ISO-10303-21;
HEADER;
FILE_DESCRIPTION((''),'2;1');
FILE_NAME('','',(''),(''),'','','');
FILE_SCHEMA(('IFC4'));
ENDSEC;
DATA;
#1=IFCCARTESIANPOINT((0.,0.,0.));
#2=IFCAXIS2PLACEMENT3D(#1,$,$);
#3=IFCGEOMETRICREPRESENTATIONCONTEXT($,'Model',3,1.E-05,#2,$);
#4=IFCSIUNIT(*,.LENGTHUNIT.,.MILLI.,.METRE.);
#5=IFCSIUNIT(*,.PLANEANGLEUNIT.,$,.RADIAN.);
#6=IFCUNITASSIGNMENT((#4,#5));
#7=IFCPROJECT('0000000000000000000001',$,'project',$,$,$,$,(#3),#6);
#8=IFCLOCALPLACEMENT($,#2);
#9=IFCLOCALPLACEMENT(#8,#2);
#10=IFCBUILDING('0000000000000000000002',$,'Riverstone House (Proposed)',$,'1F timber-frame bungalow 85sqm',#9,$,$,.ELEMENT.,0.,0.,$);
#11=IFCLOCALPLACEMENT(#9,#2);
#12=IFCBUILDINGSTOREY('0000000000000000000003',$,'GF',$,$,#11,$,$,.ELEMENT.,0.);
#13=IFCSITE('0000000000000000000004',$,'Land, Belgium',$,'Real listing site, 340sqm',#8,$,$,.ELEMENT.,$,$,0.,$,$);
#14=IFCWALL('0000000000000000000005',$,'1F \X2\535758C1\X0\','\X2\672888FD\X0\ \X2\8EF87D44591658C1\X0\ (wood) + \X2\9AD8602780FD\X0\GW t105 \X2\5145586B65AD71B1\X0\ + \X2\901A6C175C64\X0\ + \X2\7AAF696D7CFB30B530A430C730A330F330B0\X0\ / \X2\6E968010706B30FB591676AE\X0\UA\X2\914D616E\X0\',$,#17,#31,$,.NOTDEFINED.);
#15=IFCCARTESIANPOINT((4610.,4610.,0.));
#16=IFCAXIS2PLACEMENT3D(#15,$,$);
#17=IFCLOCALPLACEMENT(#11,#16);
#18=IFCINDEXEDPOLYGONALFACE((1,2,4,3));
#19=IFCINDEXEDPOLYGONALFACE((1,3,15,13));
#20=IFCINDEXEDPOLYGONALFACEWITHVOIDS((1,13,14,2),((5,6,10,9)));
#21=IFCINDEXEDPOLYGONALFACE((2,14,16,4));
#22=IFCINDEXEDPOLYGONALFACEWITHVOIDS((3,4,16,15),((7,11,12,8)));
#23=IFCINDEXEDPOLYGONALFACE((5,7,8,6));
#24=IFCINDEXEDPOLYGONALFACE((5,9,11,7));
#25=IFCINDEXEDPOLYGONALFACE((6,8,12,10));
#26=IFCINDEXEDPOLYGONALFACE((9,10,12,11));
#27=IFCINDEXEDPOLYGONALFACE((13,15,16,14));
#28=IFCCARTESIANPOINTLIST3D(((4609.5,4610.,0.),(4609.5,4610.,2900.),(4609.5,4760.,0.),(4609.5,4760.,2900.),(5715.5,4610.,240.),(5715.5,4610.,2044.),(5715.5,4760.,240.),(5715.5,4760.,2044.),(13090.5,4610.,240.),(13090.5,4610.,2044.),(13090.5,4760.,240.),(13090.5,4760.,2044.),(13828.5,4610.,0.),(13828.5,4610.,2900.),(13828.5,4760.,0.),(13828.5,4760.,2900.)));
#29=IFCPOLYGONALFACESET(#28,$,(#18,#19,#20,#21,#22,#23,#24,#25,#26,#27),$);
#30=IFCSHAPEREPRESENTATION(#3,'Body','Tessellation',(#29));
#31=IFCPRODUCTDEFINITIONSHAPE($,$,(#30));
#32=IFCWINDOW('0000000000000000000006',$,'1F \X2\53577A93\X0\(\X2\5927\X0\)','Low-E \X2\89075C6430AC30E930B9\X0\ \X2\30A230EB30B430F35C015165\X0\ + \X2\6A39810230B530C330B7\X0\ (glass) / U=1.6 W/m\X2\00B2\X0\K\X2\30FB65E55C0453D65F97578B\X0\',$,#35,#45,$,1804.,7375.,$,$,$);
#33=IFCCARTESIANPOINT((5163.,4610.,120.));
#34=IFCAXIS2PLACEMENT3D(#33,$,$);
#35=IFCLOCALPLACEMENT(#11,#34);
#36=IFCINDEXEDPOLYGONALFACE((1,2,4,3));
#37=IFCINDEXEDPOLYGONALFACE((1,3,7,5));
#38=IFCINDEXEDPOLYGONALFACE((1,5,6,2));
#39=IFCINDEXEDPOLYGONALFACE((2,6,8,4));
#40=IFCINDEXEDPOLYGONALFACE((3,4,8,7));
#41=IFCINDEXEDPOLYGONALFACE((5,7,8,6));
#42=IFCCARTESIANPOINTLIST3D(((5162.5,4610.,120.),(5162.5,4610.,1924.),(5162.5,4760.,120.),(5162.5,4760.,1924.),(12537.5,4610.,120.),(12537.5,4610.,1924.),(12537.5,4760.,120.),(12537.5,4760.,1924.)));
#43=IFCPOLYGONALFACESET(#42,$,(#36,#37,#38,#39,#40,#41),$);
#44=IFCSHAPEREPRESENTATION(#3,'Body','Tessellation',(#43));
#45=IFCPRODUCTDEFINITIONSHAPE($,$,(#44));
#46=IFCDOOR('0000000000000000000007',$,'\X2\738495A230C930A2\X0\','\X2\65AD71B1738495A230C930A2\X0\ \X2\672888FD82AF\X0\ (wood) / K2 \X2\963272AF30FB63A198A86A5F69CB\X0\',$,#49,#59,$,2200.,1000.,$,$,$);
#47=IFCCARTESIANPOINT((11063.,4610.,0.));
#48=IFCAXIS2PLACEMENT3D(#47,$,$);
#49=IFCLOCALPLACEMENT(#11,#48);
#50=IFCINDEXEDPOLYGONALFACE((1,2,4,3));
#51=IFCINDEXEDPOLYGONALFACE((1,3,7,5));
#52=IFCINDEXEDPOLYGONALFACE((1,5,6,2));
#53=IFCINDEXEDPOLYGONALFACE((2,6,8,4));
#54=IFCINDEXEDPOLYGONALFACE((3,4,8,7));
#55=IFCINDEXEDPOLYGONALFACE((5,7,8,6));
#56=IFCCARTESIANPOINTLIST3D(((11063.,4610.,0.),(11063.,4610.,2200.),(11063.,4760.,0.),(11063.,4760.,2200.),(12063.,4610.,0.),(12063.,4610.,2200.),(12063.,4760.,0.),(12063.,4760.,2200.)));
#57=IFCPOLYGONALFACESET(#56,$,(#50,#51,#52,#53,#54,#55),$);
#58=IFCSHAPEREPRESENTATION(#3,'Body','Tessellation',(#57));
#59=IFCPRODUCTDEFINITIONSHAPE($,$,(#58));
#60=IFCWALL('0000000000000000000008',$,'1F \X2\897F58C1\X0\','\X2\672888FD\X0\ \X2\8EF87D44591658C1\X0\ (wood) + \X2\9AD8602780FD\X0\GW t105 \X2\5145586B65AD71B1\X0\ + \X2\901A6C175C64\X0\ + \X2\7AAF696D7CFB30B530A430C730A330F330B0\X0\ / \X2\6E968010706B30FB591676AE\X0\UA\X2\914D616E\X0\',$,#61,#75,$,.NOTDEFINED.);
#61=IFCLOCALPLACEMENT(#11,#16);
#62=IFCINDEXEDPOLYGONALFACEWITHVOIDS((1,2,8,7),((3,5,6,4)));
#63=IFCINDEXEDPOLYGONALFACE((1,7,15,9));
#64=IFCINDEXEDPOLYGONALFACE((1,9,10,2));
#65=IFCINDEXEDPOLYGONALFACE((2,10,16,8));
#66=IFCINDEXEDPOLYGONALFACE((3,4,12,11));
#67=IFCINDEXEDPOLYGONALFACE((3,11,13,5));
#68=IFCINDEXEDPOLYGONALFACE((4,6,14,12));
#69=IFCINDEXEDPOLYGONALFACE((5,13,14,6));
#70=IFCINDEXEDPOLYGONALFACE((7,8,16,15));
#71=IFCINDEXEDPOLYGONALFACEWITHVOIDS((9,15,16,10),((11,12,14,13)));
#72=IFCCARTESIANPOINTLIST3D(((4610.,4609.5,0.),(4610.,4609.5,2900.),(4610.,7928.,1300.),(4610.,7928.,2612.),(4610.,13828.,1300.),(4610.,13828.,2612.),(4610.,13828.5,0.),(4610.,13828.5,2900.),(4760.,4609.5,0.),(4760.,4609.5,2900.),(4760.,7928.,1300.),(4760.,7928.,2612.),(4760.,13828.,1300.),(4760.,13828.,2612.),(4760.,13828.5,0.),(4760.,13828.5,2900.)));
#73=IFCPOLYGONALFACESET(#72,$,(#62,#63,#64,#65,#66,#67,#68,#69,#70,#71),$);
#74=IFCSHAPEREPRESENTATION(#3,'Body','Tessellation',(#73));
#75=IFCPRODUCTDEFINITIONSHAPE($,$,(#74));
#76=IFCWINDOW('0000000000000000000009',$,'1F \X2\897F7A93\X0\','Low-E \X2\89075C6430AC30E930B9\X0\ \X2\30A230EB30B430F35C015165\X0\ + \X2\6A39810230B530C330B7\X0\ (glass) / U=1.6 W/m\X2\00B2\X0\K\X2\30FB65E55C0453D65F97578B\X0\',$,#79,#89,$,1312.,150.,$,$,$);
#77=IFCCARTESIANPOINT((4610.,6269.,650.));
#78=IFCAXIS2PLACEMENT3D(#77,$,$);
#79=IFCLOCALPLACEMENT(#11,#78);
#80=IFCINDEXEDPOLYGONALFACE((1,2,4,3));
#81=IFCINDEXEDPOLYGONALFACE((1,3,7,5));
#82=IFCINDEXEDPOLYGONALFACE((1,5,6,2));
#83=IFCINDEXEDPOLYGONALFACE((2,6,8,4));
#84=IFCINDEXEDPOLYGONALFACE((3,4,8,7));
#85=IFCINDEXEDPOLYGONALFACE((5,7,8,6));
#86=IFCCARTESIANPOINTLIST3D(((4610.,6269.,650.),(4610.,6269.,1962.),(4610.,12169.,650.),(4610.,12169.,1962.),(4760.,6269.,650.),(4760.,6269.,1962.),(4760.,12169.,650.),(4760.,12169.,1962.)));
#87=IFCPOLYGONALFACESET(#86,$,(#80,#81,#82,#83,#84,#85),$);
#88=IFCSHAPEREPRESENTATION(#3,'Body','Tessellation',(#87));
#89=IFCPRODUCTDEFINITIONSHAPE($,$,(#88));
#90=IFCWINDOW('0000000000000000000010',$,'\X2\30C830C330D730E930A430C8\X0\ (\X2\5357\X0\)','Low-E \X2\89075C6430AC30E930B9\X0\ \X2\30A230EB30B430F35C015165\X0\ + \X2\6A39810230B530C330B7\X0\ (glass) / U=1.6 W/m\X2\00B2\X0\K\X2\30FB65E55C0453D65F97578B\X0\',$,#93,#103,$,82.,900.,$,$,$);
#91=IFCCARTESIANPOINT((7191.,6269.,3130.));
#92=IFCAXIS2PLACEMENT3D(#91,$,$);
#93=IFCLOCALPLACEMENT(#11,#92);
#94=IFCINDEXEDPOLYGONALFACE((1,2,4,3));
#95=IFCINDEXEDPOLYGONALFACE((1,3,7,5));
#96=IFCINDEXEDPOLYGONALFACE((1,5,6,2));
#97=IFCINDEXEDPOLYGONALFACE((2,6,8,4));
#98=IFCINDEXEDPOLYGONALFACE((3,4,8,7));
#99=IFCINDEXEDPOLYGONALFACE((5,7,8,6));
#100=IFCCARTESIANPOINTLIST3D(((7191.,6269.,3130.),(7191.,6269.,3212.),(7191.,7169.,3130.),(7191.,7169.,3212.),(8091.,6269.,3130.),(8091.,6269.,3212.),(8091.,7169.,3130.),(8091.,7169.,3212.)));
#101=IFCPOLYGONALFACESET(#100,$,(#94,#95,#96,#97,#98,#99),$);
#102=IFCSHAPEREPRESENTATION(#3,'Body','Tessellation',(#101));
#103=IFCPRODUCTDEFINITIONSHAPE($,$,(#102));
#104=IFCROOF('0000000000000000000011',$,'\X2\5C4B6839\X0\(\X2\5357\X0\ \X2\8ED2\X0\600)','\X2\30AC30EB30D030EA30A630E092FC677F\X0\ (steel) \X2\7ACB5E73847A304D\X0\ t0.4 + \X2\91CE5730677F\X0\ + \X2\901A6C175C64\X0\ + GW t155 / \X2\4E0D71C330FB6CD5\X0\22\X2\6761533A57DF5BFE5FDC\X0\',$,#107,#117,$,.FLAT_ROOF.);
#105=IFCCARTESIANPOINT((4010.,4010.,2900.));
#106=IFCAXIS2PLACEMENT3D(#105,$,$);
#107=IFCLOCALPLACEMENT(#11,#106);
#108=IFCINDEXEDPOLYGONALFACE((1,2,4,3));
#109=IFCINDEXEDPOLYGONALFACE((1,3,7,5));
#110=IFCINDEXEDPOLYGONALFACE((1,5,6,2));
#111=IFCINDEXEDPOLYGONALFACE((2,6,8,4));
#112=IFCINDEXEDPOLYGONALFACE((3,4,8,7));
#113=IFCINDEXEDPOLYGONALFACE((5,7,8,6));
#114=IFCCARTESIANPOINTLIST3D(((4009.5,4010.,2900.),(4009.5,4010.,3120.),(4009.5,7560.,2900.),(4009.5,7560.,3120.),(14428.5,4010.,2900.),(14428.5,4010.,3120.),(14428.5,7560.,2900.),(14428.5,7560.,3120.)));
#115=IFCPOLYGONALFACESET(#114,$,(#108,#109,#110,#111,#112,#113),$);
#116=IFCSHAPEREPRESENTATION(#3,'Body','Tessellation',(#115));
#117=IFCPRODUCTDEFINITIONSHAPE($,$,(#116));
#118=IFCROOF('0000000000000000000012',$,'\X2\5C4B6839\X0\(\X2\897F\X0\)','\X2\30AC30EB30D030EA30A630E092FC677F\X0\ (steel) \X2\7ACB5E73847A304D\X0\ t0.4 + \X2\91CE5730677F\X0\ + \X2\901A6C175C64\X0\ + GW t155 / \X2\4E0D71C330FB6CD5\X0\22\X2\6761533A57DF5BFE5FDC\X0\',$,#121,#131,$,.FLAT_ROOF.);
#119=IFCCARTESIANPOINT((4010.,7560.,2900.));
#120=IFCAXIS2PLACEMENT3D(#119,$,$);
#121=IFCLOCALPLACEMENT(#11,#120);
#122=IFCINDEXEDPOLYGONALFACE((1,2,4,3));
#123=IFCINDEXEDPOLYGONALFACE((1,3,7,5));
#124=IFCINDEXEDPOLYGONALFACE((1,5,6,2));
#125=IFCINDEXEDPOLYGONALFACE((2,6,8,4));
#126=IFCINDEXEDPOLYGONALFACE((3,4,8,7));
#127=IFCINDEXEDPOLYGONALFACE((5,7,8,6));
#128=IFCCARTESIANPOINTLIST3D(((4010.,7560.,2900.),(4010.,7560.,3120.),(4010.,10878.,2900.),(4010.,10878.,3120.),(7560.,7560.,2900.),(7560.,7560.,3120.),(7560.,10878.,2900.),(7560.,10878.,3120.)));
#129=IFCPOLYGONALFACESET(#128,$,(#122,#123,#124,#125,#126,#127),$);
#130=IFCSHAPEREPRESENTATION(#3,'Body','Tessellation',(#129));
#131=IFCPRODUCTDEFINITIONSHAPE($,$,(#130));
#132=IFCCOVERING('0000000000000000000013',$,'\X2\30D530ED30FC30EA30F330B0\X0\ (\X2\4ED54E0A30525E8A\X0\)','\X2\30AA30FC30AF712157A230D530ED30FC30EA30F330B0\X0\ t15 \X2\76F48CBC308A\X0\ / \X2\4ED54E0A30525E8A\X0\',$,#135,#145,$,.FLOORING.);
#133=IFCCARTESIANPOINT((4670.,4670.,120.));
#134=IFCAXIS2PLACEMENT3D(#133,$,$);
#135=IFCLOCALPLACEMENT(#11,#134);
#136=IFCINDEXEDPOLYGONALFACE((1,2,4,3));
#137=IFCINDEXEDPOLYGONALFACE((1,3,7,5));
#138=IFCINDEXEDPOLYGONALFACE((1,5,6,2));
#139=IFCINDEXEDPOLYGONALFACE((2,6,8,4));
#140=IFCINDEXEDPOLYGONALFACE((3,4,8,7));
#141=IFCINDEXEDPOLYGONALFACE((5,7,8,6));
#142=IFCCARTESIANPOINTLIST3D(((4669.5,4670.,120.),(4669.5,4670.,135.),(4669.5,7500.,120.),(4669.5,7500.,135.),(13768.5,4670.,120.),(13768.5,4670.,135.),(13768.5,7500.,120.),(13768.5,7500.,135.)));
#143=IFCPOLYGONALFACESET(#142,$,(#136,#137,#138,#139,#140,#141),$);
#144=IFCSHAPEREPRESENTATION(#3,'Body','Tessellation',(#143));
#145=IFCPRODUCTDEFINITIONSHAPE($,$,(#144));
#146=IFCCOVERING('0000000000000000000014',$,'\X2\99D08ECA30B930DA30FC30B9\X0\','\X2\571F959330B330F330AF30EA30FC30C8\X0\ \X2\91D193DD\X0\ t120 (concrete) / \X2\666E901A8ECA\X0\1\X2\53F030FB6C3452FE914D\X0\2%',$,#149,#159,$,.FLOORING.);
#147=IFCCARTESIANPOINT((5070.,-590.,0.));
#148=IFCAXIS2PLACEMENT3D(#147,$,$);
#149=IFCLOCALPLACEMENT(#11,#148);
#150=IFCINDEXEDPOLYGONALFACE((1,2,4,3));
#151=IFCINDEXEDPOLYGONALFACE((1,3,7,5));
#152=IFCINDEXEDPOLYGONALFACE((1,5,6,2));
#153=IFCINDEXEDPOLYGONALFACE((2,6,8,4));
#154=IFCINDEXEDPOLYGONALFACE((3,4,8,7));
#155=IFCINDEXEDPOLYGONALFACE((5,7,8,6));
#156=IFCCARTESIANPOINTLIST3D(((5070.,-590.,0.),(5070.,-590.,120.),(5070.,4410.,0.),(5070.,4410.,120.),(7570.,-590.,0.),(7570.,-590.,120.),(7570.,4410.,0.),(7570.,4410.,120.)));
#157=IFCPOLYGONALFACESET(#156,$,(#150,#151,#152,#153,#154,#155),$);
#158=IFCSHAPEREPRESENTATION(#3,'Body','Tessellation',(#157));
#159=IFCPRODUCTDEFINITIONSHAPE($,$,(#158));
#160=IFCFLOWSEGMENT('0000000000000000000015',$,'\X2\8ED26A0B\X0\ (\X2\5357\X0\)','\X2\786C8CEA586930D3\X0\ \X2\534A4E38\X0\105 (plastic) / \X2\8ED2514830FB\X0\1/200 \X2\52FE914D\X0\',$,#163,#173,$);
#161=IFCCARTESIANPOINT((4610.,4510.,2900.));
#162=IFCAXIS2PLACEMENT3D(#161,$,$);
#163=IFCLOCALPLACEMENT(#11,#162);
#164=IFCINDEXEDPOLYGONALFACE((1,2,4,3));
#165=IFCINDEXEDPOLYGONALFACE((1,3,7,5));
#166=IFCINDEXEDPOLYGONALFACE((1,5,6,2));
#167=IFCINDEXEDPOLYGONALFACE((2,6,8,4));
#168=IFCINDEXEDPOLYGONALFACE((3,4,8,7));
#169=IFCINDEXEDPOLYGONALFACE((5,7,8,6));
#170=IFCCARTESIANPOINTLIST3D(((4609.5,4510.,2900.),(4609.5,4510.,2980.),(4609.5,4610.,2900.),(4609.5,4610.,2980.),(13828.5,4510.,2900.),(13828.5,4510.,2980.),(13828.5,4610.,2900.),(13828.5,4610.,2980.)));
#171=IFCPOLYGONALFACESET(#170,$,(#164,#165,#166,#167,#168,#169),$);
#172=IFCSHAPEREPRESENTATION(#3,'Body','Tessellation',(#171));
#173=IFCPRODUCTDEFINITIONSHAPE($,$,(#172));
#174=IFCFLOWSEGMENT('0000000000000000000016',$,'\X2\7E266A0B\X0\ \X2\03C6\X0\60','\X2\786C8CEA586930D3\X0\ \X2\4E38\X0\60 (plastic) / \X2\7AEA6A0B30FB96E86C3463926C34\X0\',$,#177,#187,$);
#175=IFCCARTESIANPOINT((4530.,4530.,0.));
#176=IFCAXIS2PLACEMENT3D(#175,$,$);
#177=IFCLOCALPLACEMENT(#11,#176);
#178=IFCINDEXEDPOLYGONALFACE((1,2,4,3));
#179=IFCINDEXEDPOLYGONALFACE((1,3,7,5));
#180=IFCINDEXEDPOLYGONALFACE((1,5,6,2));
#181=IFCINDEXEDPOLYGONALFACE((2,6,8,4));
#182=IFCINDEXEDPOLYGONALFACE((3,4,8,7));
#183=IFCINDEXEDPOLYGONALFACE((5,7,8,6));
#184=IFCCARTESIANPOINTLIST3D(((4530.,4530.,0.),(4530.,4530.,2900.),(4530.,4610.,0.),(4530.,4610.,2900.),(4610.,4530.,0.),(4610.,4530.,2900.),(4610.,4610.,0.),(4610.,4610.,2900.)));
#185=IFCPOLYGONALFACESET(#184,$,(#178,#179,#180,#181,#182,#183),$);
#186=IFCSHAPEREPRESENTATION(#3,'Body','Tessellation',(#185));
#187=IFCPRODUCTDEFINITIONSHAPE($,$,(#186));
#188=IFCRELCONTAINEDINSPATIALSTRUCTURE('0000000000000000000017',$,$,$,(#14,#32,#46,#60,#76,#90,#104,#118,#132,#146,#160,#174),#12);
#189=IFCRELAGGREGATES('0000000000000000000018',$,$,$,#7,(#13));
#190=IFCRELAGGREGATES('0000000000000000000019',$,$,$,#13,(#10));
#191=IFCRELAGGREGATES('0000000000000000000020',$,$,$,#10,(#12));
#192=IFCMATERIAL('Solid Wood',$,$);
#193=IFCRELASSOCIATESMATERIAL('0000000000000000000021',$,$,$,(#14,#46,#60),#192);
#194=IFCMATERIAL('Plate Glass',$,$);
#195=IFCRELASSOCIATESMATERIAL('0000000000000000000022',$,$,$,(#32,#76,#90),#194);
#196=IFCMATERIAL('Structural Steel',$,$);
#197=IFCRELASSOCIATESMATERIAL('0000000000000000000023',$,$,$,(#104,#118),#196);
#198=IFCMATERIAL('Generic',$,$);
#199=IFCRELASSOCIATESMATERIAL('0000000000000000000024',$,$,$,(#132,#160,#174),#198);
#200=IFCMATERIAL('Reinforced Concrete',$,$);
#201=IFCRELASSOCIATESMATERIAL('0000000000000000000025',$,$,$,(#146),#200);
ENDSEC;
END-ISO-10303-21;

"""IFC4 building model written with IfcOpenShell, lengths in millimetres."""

from ifc_helpers import new_model, si_unit, frame, frame_2d, origin, place, context, project, spatial, rectangle, extrude, material, element, fill, save


model = new_model("IFC4")

# Units and contexts
model_context = context("Model", 3, precision=1e-05, world=origin())
ifc_project = project(units=[si_unit("LENGTHUNIT", "METRE", prefix="MILLI"), si_unit("PLANEANGLEUNIT", "RADIAN")], contexts=[model_context])

# Site, building, storey
site_placement = place(None, origin())
site = spatial("IfcSite", under=ifc_project, at=site_placement, Name="Land, Belgium", ObjectType="Real listing site, 340sqm", CompositionType="ELEMENT", RefElevation=0.0)
building_placement = place(site_placement, origin())
building = spatial("IfcBuilding", under=site, at=building_placement, Name="Riverstone House (Proposed)", ObjectType="1F timber-frame bungalow 85sqm", CompositionType="ELEMENT", ElevationOfRefHeight=0.0, ElevationOfTerrain=0.0)
storey_placement = place(building_placement, origin())
storey = spatial("IfcBuildingStorey", under=building, at=storey_placement, Name="GF", CompositionType="ELEMENT", Elevation=0.0)

# Shared definitions
ifc_material_1 = material(Name="Solid Wood")

# Shared definitions
ifc_material_2 = material(Name="Reinforced Concrete")

# Wall, openings, window, door
wall_1_placement = place(storey_placement, frame((4610.0, 4610.0, 0.0)))
wall_1 = element("IfcWall", 1, at=wall_1_placement, inside=storey, material=ifc_material_1, Name="1F 南壁", Description="木製 軸組外壁 (wood) + 高性能GW t105 充填断熱 + 通気層 + 窯業系サイディング / 準耐火・外皮UA配慮", PredefinedType="NOTDEFINED", context=model_context, shape_type="SweptSolid", body=[
    extrude(rectangle(XDim=9219.0, YDim=150.0, at=frame_2d((4609.0, 75.0))), frame((4610.0, 4610.0, 0.0)), (0.0, 0.0, 1.0), 2900.0),
])
opening_1_placement = place(storey_placement, frame((5163.0, 4610.0, 120.0)))
opening_1 = element("IfcOpeningElement", 2, at=opening_1_placement, cuts=wall_1, PredefinedType="NOTDEFINED", context=model_context, shape_type="SweptSolid", body=[
    extrude(rectangle(XDim=7375.0, YDim=150.0, at=frame_2d((3687.0, 75.0))), frame((5163.0, 4610.0, 120.0)), (0.0, 0.0, 1.0), 1804.0),
])
opening_2_placement = place(storey_placement, frame((11063.0, 4610.0, 0.0)))
opening_2 = element("IfcOpeningElement", 3, at=opening_2_placement, cuts=wall_1, PredefinedType="NOTDEFINED", context=model_context, shape_type="SweptSolid", body=[
    extrude(rectangle(XDim=1000.0, YDim=150.0, at=frame_2d((500.0, 75.0))), frame((11063.0, 4610.0, 0.0)), (0.0, 0.0, 1.0), 2200.0),
])
ifc_material_3 = material(Name="Plate Glass")
window_1_placement = place(storey_placement, frame((5163.0, 4610.0, 120.0)))
window_1 = element("IfcWindow", 4, at=window_1_placement, inside=storey, material=ifc_material_3, Name="1F 南窓(大)", Description="Low-E 複層ガラス アルゴン封入 + 樹脂サッシ (glass) / U=1.6 W/m²K・日射取得型", OverallHeight=1804.0, OverallWidth=7375.0, context=model_context, shape_type="SweptSolid", body=[
    extrude(rectangle(XDim=7375.0, YDim=150.0, at=frame_2d((3687.0, 75.0))), frame((5163.0, 4610.0, 120.0)), (0.0, 0.0, 1.0), 1804.0),
])
fill(opening_1, window_1)
door_placement = place(storey_placement, frame((11063.0, 4610.0, 0.0)))
door = element("IfcDoor", 5, at=door_placement, inside=storey, material=ifc_material_1, Name="玄関ドア", Description="断熱玄関ドア 木製芯 (wood) / K2 防犯・採風機構", OverallHeight=2200.0, OverallWidth=1000.0, context=model_context, shape_type="SweptSolid", body=[
    extrude(rectangle(XDim=1000.0, YDim=150.0, at=frame_2d((500.0, 75.0))), frame((11063.0, 4610.0, 0.0)), (0.0, 0.0, 1.0), 2200.0),
])
fill(opening_2, door)

# Wall, opening, window
wall_2_placement = place(storey_placement, frame((4610.0, 4610.0, 0.0)))
wall_2 = element("IfcWall", 6, at=wall_2_placement, inside=storey, material=ifc_material_1, Name="1F 西壁", Description="木製 軸組外壁 (wood) + 高性能GW t105 充填断熱 + 通気層 + 窯業系サイディング / 準耐火・外皮UA配慮", PredefinedType="NOTDEFINED", context=model_context, shape_type="SweptSolid", body=[
    extrude(rectangle(XDim=150.0, YDim=9219.0, at=frame_2d((75.0, 4609.0))), frame((4610.0, 4610.0, 0.0)), (0.0, 0.0, 1.0), 2900.0),
])
opening_3_placement = place(storey_placement, frame((4610.0, 6269.0, 650.0)))
opening_3 = element("IfcOpeningElement", 7, at=opening_3_placement, cuts=wall_2, PredefinedType="NOTDEFINED", context=model_context, shape_type="SweptSolid", body=[
    extrude(rectangle(XDim=150.0, YDim=5900.0, at=frame_2d((75.0, 2950.0))), frame((4610.0, 6269.0, 650.0)), (0.0, 0.0, 1.0), 1312.0),
])
window_2_placement = place(storey_placement, frame((4610.0, 6269.0, 650.0)))
window_2 = element("IfcWindow", 8, at=window_2_placement, inside=storey, material=ifc_material_3, Name="1F 西窓", Description="Low-E 複層ガラス アルゴン封入 + 樹脂サッシ (glass) / U=1.6 W/m²K・日射取得型", OverallHeight=1312.0, OverallWidth=150.0, context=model_context, shape_type="SweptSolid", body=[
    extrude(rectangle(XDim=150.0, YDim=5900.0, at=frame_2d((75.0, 2950.0))), frame((4610.0, 6269.0, 650.0)), (0.0, 0.0, 1.0), 1312.0),
])
fill(opening_3, window_2)

# Window
window_3_placement = place(storey_placement, frame((7191.0, 6269.0, 3130.0)))
element("IfcWindow", 9, at=window_3_placement, inside=storey, material=ifc_material_3, Name="トップライト (南)", Description="Low-E 複層ガラス アルゴン封入 + 樹脂サッシ (glass) / U=1.6 W/m²K・日射取得型", OverallHeight=82.0, OverallWidth=900.0, context=model_context, shape_type="SweptSolid", body=[
    extrude(rectangle(XDim=900.0, YDim=900.0, at=frame_2d((450.0, 450.0))), frame((7191.0, 6269.0, 3130.0)), (0.0, 0.0, 1.0), 82.0),
])

# Roofs
ifc_material_4 = material(Name="Structural Steel")
roof_1_placement = place(storey_placement, frame((4010.0, 4010.0, 2900.0)))
element("IfcRoof", 10, at=roof_1_placement, inside=storey, material=ifc_material_4, Name="屋根(南 軒600)", Description="ガルバリウム鋼板 (steel) 立平葺き t0.4 + 野地板 + 通気層 + GW t155 / 不燃・法22条区域対応", PredefinedType="FLAT_ROOF", context=model_context, shape_type="SweptSolid", body=[
    extrude(rectangle(XDim=10419.0, YDim=3550.0, at=frame_2d((5209.0, 1775.0))), frame((4010.0, 4010.0, 2900.0)), (0.0, 0.0, 1.0), 220.0),
])
roof_2_placement = place(storey_placement, frame((4010.0, 7560.0, 2900.0)))
element("IfcRoof", 11, at=roof_2_placement, inside=storey, material=ifc_material_4, Name="屋根(西)", Description="ガルバリウム鋼板 (steel) 立平葺き t0.4 + 野地板 + 通気層 + GW t155 / 不燃・法22条区域対応", PredefinedType="FLAT_ROOF", context=model_context, shape_type="SweptSolid", body=[
    extrude(rectangle(XDim=3550.0, YDim=3318.0, at=frame_2d((1775.0, 1659.0))), frame((4010.0, 7560.0, 2900.0)), (0.0, 0.0, 1.0), 220.0),
])

# Coverings
ifc_material_5 = material(Name="Generic")
covering_1_placement = place(storey_placement, frame((4670.0, 4670.0, 120.0)))
element("IfcCovering", 12, at=covering_1_placement, inside=storey, material=ifc_material_5, Name="フローリング (仕上げ床)", Description="オーク無垢フローリング t15 直貼り / 仕上げ床", PredefinedType="FLOORING", context=model_context, shape_type="SweptSolid", body=[
    extrude(rectangle(XDim=9099.0, YDim=2830.0, at=frame_2d((4549.0, 1415.0))), frame((4670.0, 4670.0, 120.0)), (0.0, 0.0, 1.0), 15.0),
])
covering_2_placement = place(storey_placement, frame((5070.0, -590.0, 0.0)))
element("IfcCovering", 13, at=covering_2_placement, inside=storey, material=ifc_material_2, Name="駐車スペース", Description="土間コンクリート 金鏝 t120 (concrete) / 普通車1台・水勾配2%", PredefinedType="FLOORING", context=model_context, shape_type="SweptSolid", body=[
    extrude(rectangle(XDim=2500.0, YDim=5000.0, at=frame_2d((1250.0, 2500.0))), frame((5070.0, -590.0, 0.0)), (0.0, 0.0, 1.0), 120.0),
])

# Flow segments
flow_segment_1_placement = place(storey_placement, frame((4610.0, 4510.0, 2900.0)))
element("IfcFlowSegment", 14, at=flow_segment_1_placement, inside=storey, material=ifc_material_5, Name="軒樋 (南)", Description="硬質塩ビ 半丸105 (plastic) / 軒先・1/200 勾配", context=model_context, shape_type="SweptSolid", body=[
    extrude(rectangle(XDim=9219.0, YDim=100.0, at=frame_2d((4609.0, 50.0))), frame((4610.0, 4510.0, 2900.0)), (0.0, 0.0, 1.0), 80.0),
])
flow_segment_2_placement = place(storey_placement, frame((4530.0, 4530.0, 0.0)))
element("IfcFlowSegment", 15, at=flow_segment_2_placement, inside=storey, material=ifc_material_5, Name="縦樋 φ60", Description="硬質塩ビ 丸60 (plastic) / 竪樋・雨水排水", context=model_context, shape_type="SweptSolid", body=[
    extrude(rectangle(XDim=80.0, YDim=80.0, at=frame_2d((40.0, 40.0))), frame((4530.0, 4530.0, 0.0)), (0.0, 0.0, 1.0), 2900.0),
])

save(model, "model.ifc")
